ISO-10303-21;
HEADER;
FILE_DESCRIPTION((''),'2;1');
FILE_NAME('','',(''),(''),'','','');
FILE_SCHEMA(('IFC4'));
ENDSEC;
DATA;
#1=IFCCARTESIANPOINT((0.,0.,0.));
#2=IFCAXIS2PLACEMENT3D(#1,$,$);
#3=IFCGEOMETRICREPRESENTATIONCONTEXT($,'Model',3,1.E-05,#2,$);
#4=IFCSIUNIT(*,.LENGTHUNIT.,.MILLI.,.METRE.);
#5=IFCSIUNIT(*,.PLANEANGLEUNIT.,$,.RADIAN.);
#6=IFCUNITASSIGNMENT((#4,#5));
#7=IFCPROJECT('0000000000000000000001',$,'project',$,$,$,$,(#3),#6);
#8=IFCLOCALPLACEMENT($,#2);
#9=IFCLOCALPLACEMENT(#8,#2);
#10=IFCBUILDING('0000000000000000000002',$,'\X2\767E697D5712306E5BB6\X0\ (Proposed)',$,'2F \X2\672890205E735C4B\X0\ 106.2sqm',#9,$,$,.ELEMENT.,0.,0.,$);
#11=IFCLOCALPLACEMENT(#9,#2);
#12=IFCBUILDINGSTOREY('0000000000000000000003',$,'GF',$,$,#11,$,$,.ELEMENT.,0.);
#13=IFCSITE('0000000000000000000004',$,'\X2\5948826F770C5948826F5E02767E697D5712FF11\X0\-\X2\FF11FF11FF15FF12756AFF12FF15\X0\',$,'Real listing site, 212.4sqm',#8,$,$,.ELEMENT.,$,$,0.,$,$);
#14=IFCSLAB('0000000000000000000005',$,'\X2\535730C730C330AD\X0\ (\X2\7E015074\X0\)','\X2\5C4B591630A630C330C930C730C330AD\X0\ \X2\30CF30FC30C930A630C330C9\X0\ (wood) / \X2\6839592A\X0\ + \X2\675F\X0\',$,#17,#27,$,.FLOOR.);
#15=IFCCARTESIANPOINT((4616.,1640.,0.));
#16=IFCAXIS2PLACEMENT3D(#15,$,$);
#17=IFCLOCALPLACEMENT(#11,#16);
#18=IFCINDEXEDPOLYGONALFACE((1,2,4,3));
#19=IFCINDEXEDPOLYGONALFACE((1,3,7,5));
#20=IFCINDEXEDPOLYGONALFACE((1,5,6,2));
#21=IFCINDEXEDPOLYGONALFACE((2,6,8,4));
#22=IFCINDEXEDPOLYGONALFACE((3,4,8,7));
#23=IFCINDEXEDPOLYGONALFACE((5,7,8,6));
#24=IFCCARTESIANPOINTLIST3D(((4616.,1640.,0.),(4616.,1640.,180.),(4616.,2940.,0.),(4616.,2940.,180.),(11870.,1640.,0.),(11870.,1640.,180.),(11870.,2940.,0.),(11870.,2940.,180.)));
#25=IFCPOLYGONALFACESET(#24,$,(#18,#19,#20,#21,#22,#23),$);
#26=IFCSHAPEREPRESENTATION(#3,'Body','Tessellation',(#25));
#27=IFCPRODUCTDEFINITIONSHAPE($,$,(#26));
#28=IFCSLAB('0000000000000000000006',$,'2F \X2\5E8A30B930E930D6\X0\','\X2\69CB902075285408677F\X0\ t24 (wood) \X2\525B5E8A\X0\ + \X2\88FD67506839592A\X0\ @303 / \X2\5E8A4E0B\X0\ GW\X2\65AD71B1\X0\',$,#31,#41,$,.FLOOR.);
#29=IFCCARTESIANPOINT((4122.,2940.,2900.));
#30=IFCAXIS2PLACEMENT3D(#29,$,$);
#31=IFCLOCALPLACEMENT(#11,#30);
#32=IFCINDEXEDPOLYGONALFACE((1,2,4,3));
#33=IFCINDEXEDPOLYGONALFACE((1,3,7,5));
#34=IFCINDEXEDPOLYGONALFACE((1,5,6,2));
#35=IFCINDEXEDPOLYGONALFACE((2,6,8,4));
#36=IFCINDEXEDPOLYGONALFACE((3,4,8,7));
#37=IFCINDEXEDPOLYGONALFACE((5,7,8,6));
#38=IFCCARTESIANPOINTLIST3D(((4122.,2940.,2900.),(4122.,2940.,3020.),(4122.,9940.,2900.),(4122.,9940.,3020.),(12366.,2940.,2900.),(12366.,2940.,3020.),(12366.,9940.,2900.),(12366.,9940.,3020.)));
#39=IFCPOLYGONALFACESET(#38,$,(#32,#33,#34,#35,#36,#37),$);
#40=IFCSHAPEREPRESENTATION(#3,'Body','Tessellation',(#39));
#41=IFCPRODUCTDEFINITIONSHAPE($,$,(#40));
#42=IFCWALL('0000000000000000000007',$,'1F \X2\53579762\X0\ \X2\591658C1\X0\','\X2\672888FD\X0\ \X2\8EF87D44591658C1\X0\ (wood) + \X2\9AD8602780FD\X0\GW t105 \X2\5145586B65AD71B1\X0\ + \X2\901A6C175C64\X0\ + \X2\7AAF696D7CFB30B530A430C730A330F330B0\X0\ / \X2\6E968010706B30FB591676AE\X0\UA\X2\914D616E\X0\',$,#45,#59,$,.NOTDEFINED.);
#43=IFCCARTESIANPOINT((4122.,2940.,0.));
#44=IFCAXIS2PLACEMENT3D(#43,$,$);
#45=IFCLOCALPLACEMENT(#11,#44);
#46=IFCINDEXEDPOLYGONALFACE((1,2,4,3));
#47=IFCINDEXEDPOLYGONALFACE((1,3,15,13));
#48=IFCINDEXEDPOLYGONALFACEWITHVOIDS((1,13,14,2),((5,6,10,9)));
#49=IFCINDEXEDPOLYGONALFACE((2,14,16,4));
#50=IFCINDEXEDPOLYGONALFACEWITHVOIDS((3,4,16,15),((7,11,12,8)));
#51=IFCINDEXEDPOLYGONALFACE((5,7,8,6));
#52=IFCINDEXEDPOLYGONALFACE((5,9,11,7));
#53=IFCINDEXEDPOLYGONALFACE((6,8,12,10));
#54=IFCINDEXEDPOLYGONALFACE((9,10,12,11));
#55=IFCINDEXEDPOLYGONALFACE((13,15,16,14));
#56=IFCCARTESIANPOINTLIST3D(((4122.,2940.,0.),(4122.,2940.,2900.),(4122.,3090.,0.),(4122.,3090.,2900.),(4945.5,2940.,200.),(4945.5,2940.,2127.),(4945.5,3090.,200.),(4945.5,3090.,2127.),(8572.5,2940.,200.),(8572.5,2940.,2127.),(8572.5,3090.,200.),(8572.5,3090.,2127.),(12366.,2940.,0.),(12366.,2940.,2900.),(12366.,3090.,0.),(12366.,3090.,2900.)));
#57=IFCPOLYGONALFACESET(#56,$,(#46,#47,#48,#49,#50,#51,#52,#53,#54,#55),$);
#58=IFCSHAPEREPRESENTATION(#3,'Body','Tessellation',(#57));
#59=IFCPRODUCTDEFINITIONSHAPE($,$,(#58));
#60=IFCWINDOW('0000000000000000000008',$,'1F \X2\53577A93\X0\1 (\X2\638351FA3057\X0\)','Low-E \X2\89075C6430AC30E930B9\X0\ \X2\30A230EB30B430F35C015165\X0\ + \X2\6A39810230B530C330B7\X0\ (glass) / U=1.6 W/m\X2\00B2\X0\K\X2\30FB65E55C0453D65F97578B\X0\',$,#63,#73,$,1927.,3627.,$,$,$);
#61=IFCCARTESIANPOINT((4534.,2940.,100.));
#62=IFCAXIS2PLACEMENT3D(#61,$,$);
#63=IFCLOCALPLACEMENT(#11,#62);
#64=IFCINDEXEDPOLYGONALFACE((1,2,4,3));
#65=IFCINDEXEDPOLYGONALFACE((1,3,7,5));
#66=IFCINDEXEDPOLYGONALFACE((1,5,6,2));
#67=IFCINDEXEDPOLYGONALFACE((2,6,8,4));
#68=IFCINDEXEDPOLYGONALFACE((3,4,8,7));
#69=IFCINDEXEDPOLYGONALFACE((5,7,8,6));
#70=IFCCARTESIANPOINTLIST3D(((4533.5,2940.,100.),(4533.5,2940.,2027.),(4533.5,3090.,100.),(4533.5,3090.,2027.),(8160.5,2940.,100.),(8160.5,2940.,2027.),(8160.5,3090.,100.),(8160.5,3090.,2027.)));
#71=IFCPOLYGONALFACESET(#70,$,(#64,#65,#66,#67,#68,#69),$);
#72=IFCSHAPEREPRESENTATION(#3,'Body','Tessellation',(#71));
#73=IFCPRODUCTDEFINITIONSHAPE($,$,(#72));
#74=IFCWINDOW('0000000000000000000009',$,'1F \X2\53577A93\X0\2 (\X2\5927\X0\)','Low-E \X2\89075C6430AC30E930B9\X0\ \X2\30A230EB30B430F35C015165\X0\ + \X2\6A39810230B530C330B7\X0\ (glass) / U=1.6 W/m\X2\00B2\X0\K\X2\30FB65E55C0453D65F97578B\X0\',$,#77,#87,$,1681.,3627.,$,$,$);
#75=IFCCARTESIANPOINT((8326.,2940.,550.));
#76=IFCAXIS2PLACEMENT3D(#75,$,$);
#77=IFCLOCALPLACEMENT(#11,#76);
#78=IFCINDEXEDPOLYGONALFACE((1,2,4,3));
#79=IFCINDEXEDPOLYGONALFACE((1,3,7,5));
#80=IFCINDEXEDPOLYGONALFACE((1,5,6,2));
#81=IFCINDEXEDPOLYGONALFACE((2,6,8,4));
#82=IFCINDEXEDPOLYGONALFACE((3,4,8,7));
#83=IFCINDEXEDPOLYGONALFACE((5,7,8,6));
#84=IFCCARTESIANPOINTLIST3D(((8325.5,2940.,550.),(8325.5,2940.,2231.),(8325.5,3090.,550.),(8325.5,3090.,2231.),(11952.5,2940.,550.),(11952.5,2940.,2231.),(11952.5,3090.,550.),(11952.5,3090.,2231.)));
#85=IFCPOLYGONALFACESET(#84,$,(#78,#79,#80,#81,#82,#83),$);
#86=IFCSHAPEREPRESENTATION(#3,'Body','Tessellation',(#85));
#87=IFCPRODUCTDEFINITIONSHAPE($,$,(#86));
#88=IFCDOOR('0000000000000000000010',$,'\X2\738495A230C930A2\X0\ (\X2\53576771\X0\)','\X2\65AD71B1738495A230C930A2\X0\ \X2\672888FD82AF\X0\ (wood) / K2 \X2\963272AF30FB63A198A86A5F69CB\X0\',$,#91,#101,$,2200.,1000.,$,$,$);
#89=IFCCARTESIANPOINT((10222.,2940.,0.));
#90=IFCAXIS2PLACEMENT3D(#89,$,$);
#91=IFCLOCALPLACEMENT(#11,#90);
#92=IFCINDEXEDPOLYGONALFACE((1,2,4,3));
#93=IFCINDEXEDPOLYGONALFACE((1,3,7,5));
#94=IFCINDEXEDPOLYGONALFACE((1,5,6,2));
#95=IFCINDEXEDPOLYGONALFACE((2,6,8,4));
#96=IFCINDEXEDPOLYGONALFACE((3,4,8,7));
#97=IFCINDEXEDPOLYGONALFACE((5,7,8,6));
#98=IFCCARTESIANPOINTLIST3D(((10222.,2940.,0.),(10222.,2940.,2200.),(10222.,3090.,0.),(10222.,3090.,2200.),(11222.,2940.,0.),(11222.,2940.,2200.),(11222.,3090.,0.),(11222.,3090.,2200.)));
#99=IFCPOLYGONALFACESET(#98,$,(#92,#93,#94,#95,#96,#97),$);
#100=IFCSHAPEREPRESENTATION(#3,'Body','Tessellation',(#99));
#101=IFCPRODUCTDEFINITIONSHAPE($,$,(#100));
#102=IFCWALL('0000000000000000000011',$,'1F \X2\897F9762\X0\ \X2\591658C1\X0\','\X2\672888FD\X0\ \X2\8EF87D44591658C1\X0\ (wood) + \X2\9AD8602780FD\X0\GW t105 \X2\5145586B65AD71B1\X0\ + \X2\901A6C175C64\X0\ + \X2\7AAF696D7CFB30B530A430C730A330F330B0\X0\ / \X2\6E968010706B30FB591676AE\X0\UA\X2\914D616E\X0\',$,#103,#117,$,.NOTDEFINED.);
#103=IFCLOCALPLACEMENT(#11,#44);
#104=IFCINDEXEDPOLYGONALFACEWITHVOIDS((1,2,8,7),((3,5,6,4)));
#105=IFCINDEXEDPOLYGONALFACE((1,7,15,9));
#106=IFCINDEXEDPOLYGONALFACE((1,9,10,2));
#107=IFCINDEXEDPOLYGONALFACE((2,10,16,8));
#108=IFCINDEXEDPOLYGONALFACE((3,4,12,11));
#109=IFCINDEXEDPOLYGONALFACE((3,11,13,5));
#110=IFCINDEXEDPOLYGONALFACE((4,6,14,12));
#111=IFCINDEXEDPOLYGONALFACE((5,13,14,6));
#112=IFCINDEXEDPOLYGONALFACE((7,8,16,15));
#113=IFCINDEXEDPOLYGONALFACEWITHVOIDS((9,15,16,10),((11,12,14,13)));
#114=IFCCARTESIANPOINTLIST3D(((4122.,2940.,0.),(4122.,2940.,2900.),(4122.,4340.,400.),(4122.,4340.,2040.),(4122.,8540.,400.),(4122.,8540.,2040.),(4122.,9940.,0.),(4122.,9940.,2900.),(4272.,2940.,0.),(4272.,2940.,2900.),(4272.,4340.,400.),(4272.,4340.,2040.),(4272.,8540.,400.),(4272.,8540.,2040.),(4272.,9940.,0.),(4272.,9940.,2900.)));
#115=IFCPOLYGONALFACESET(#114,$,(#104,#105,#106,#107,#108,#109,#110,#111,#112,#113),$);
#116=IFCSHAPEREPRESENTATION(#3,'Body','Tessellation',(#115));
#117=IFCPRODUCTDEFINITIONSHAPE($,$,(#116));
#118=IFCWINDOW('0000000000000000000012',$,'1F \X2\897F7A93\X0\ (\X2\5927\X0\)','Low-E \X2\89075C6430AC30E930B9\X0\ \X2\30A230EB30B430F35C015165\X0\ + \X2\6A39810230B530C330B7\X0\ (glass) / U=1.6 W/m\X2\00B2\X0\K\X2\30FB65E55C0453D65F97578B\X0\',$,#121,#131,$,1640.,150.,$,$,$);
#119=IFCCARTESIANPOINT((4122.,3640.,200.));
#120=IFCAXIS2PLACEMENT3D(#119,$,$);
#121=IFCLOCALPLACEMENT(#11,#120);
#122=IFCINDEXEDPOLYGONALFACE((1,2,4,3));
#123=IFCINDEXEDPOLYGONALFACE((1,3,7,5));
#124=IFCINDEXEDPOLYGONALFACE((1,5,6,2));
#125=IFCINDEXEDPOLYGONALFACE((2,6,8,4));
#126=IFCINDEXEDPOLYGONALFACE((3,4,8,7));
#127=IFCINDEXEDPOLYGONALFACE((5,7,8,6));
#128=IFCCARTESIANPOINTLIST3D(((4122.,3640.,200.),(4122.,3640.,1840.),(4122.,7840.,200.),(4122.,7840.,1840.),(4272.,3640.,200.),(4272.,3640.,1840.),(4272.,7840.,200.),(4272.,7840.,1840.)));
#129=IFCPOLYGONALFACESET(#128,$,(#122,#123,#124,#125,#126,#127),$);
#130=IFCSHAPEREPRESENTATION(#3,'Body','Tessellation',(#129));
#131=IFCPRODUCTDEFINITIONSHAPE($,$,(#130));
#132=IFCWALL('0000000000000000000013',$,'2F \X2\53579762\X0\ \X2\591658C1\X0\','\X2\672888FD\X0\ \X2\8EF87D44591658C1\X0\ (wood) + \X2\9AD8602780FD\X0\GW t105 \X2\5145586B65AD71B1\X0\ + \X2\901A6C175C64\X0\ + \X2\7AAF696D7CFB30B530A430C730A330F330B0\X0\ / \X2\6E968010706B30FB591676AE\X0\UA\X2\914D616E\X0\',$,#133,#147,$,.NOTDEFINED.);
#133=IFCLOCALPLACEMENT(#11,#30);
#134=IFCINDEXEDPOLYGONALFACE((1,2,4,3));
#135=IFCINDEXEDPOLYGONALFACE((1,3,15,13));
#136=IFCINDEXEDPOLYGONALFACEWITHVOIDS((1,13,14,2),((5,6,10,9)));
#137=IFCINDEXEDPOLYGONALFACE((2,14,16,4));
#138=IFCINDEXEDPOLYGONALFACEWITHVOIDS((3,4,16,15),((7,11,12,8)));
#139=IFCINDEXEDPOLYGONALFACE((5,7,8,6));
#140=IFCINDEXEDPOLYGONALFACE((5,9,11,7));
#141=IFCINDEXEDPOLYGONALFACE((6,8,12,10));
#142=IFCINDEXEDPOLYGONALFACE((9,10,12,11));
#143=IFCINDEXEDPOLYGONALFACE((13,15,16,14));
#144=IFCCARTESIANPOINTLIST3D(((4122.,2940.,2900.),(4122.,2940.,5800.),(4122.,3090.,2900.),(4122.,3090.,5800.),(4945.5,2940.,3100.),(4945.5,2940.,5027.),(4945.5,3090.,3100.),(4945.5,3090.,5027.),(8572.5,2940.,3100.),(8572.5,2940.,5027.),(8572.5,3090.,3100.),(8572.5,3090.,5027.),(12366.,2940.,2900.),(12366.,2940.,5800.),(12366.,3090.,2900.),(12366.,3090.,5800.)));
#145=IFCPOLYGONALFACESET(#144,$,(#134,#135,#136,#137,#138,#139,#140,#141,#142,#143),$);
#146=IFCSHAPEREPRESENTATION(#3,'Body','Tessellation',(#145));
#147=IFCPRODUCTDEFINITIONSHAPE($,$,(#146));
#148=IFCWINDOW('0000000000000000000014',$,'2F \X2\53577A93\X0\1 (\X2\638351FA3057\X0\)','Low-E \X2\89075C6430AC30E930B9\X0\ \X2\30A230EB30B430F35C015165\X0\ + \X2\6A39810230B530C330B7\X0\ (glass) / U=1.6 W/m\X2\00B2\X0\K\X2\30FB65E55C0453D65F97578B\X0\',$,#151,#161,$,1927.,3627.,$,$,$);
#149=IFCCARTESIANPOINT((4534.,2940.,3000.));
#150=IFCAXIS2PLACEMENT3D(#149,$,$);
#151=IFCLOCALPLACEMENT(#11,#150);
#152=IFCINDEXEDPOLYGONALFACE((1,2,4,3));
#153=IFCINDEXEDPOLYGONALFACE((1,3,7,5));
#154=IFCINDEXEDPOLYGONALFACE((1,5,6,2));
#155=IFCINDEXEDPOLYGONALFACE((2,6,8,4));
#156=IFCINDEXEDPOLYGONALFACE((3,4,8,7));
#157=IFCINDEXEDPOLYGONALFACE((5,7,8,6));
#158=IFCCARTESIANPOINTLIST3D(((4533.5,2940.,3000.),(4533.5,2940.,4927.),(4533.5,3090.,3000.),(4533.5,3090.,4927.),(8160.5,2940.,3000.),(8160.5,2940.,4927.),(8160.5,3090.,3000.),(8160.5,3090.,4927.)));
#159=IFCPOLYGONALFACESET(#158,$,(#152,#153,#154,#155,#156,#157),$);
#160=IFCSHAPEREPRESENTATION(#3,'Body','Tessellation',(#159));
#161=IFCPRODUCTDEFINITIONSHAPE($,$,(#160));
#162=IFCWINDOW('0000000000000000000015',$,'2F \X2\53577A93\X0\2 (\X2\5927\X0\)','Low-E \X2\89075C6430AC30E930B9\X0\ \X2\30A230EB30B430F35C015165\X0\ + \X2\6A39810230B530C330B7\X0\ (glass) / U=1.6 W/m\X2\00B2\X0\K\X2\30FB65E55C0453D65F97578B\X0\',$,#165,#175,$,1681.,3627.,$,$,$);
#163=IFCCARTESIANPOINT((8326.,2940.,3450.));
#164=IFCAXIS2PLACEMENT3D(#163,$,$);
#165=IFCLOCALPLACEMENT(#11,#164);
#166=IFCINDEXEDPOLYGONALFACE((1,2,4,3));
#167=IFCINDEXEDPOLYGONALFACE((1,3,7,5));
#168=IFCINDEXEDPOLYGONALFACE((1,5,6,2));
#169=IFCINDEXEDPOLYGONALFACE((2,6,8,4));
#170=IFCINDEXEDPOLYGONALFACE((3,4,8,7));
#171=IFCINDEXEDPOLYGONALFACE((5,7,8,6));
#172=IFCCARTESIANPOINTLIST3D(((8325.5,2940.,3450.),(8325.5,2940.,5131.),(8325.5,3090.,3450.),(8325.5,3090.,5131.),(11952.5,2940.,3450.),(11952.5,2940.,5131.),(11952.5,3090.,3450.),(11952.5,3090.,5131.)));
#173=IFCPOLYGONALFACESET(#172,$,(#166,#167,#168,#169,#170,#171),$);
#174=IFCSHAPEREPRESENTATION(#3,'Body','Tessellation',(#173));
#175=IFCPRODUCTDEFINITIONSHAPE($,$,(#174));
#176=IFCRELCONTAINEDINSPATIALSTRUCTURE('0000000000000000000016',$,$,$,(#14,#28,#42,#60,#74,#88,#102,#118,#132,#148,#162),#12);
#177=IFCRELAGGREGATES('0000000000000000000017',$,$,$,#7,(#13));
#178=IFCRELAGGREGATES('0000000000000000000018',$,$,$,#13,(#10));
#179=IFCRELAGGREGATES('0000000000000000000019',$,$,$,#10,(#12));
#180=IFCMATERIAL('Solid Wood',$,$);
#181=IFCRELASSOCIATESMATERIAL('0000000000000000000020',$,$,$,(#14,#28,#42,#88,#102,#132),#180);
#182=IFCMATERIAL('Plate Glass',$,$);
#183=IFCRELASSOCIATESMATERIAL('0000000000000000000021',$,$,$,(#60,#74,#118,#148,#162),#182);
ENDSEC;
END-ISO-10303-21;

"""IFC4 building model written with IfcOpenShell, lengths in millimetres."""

from ifc_helpers import new_model, si_unit, frame, frame_2d, origin, place, context, project, spatial, rectangle, extrude, material, element, fill, save


model = new_model("IFC4")

# Units and contexts
model_context = context("Model", 3, precision=1e-05, world=origin())
ifc_project = project(units=[si_unit("LENGTHUNIT", "METRE", prefix="MILLI"), si_unit("PLANEANGLEUNIT", "RADIAN")], contexts=[model_context])

# Site, building, storey
site_placement = place(None, origin())
site = spatial("IfcSite", under=ifc_project, at=site_placement, Name="奈良県奈良市百楽園１-１１５２番２５", ObjectType="Real listing site, 212.4sqm", CompositionType="ELEMENT", RefElevation=0.0)
building_placement = place(site_placement, origin())
building = spatial("IfcBuilding", under=site, at=building_placement, Name="百楽園の家 (Proposed)", ObjectType="2F 木造平屋 106.2sqm", CompositionType="ELEMENT", ElevationOfRefHeight=0.0, ElevationOfTerrain=0.0)
storey_placement = place(building_placement, origin())
storey = spatial("IfcBuildingStorey", under=building, at=storey_placement, Name="GF", CompositionType="ELEMENT", Elevation=0.0)

# Slabs
ifc_material_1 = material(Name="Solid Wood")
slab_1_placement = place(storey_placement, frame((4616.0, 1640.0, 0.0)))
element("IfcSlab", 1, at=slab_1_placement, inside=storey, material=ifc_material_1, Name="南デッキ (縁側)", Description="屋外ウッドデッキ ハードウッド (wood) / 根太 + 束", PredefinedType="FLOOR", context=model_context, shape_type="SweptSolid", body=[
    extrude(rectangle(XDim=7254.0, YDim=1300.0, at=frame_2d((3627.0, 650.0))), frame((4616.0, 1640.0, 0.0)), (0.0, 0.0, 1.0), 180.0),
])
slab_2_placement = place(storey_placement, frame((4122.0, 2940.0, 2900.0)))
element("IfcSlab", 2, at=slab_2_placement, inside=storey, material=ifc_material_1, Name="2F 床スラブ", Description="構造用合板 t24 (wood) 剛床 + 製材根太 @303 / 床下 GW断熱", PredefinedType="FLOOR", context=model_context, shape_type="SweptSolid", body=[
    extrude(rectangle(XDim=8244.0, YDim=7000.0, at=frame_2d((4122.0, 3500.0))), frame((4122.0, 2940.0, 2900.0)), (0.0, 0.0, 1.0), 120.0),
])

# Wall, openings, windows, door
wall_1_placement = place(storey_placement, frame((4122.0, 2940.0, 0.0)))
wall_1 = element("IfcWall", 3, at=wall_1_placement, inside=storey, material=ifc_material_1, Name="1F 南面 外壁", Description="木製 軸組外壁 (wood) + 高性能GW t105 充填断熱 + 通気層 + 窯業系サイディング / 準耐火・外皮UA配慮", PredefinedType="NOTDEFINED", context=model_context, shape_type="SweptSolid", body=[
    extrude(rectangle(XDim=8244.0, YDim=150.0, at=frame_2d((4122.0, 75.0))), frame((4122.0, 2940.0, 0.0)), (0.0, 0.0, 1.0), 2900.0),
])
opening_1_placement = place(storey_placement, frame((4534.0, 2940.0, 100.0)))
opening_1 = element("IfcOpeningElement", 4, at=opening_1_placement, cuts=wall_1, PredefinedType="NOTDEFINED", context=model_context, shape_type="SweptSolid", body=[
    extrude(rectangle(XDim=3627.0, YDim=150.0, at=frame_2d((1813.0, 75.0))), frame((4534.0, 2940.0, 100.0)), (0.0, 0.0, 1.0), 1927.0),
])
opening_2_placement = place(storey_placement, frame((8326.0, 2940.0, 550.0)))
opening_2 = element("IfcOpeningElement", 5, at=opening_2_placement, cuts=wall_1, PredefinedType="NOTDEFINED", context=model_context, shape_type="SweptSolid", body=[
    extrude(rectangle(XDim=3627.0, YDim=150.0, at=frame_2d((1813.0, 75.0))), frame((8326.0, 2940.0, 550.0)), (0.0, 0.0, 1.0), 1681.0),
])
opening_3_placement = place(storey_placement, frame((10222.0, 2940.0, 0.0)))
opening_3 = element("IfcOpeningElement", 6, at=opening_3_placement, cuts=wall_1, PredefinedType="NOTDEFINED", context=model_context, shape_type="SweptSolid", body=[
    extrude(rectangle(XDim=1000.0, YDim=150.0, at=frame_2d((500.0, 75.0))), frame((10222.0, 2940.0, 0.0)), (0.0, 0.0, 1.0), 2200.0),
])
ifc_material_2 = material(Name="Plate Glass")
window_1_placement = place(storey_placement, frame((4534.0, 2940.0, 100.0)))
window_1 = element("IfcWindow", 7, at=window_1_placement, inside=storey, material=ifc_material_2, Name="1F 南窓1 (掃出し)", Description="Low-E 複層ガラス アルゴン封入 + 樹脂サッシ (glass) / U=1.6 W/m²K・日射取得型", OverallHeight=1927.0, OverallWidth=3627.0, context=model_context, shape_type="SweptSolid", body=[
    extrude(rectangle(XDim=3627.0, YDim=150.0, at=frame_2d((1813.0, 75.0))), frame((4534.0, 2940.0, 100.0)), (0.0, 0.0, 1.0), 1927.0),
])
fill(opening_1, window_1)
window_2_placement = place(storey_placement, frame((8326.0, 2940.0, 550.0)))
window_2 = element("IfcWindow", 8, at=window_2_placement, inside=storey, material=ifc_material_2, Name="1F 南窓2 (大)", Description="Low-E 複層ガラス アルゴン封入 + 樹脂サッシ (glass) / U=1.6 W/m²K・日射取得型", OverallHeight=1681.0, OverallWidth=3627.0, context=model_context, shape_type="SweptSolid", body=[
    extrude(rectangle(XDim=3627.0, YDim=150.0, at=frame_2d((1813.0, 75.0))), frame((8326.0, 2940.0, 550.0)), (0.0, 0.0, 1.0), 1681.0),
])
fill(opening_2, window_2)
door_placement = place(storey_placement, frame((10222.0, 2940.0, 0.0)))
door = element("IfcDoor", 9, at=door_placement, inside=storey, material=ifc_material_1, Name="玄関ドア (南東)", Description="断熱玄関ドア 木製芯 (wood) / K2 防犯・採風機構", OverallHeight=2200.0, OverallWidth=1000.0, context=model_context, shape_type="SweptSolid", body=[
    extrude(rectangle(XDim=1000.0, YDim=150.0, at=frame_2d((500.0, 75.0))), frame((10222.0, 2940.0, 0.0)), (0.0, 0.0, 1.0), 2200.0),
])
fill(opening_3, door)

# Wall, opening, window
wall_2_placement = place(storey_placement, frame((4122.0, 2940.0, 0.0)))
wall_2 = element("IfcWall", 10, at=wall_2_placement, inside=storey, material=ifc_material_1, Name="1F 西面 外壁", Description="木製 軸組外壁 (wood) + 高性能GW t105 充填断熱 + 通気層 + 窯業系サイディング / 準耐火・外皮UA配慮", PredefinedType="NOTDEFINED", context=model_context, shape_type="SweptSolid", body=[
    extrude(rectangle(XDim=150.0, YDim=7000.0, at=frame_2d((75.0, 3500.0))), frame((4122.0, 2940.0, 0.0)), (0.0, 0.0, 1.0), 2900.0),
])
opening_4_placement = place(storey_placement, frame((4122.0, 3640.0, 200.0)))
opening_4 = element("IfcOpeningElement", 11, at=opening_4_placement, cuts=wall_2, PredefinedType="NOTDEFINED", context=model_context, shape_type="SweptSolid", body=[
    extrude(rectangle(XDim=150.0, YDim=4200.0, at=frame_2d((75.0, 2100.0))), frame((4122.0, 3640.0, 200.0)), (0.0, 0.0, 1.0), 1640.0),
])
window_3_placement = place(storey_placement, frame((4122.0, 3640.0, 200.0)))
window_3 = element("IfcWindow", 12, at=window_3_placement, inside=storey, material=ifc_material_2, Name="1F 西窓 (大)", Description="Low-E 複層ガラス アルゴン封入 + 樹脂サッシ (glass) / U=1.6 W/m²K・日射取得型", OverallHeight=1640.0, OverallWidth=150.0, context=model_context, shape_type="SweptSolid", body=[
    extrude(rectangle(XDim=150.0, YDim=4200.0, at=frame_2d((75.0, 2100.0))), frame((4122.0, 3640.0, 200.0)), (0.0, 0.0, 1.0), 1640.0),
])
fill(opening_4, window_3)

# Wall, openings, windows
wall_3_placement = place(storey_placement, frame((4122.0, 2940.0, 2900.0)))
wall_3 = element("IfcWall", 13, at=wall_3_placement, inside=storey, material=ifc_material_1, Name="2F 南面 外壁", Description="木製 軸組外壁 (wood) + 高性能GW t105 充填断熱 + 通気層 + 窯業系サイディング / 準耐火・外皮UA配慮", PredefinedType="NOTDEFINED", context=model_context, shape_type="SweptSolid", body=[
    extrude(rectangle(XDim=8244.0, YDim=150.0, at=frame_2d((4122.0, 75.0))), frame((4122.0, 2940.0, 2900.0)), (0.0, 0.0, 1.0), 2900.0),
])
opening_5_placement = place(storey_placement, frame((4534.0, 2940.0, 3000.0)))
opening_5 = element("IfcOpeningElement", 14, at=opening_5_placement, cuts=wall_3, PredefinedType="NOTDEFINED", context=model_context, shape_type="SweptSolid", body=[
    extrude(rectangle(XDim=3627.0, YDim=150.0, at=frame_2d((1813.0, 75.0))), frame((4534.0, 2940.0, 3000.0)), (0.0, 0.0, 1.0), 1927.0),
])
opening_6_placement = place(storey_placement, frame((8326.0, 2940.0, 3450.0)))
opening_6 = element("IfcOpeningElement", 15, at=opening_6_placement, cuts=wall_3, PredefinedType="NOTDEFINED", context=model_context, shape_type="SweptSolid", body=[
    extrude(rectangle(XDim=3627.0, YDim=150.0, at=frame_2d((1813.0, 75.0))), frame((8326.0, 2940.0, 3450.0)), (0.0, 0.0, 1.0), 1681.0),
])
window_4_placement = place(storey_placement, frame((4534.0, 2940.0, 3000.0)))
window_4 = element("IfcWindow", 16, at=window_4_placement, inside=storey, material=ifc_material_2, Name="2F 南窓1 (掃出し)", Description="Low-E 複層ガラス アルゴン封入 + 樹脂サッシ (glass) / U=1.6 W/m²K・日射取得型", OverallHeight=1927.0, OverallWidth=3627.0, context=model_context, shape_type="SweptSolid", body=[
    extrude(rectangle(XDim=3627.0, YDim=150.0, at=frame_2d((1813.0, 75.0))), frame((4534.0, 2940.0, 3000.0)), (0.0, 0.0, 1.0), 1927.0),
])
fill(opening_5, window_4)
window_5_placement = place(storey_placement, frame((8326.0, 2940.0, 3450.0)))
window_5 = element("IfcWindow", 17, at=window_5_placement, inside=storey, material=ifc_material_2, Name="2F 南窓2 (大)", Description="Low-E 複層ガラス アルゴン封入 + 樹脂サッシ (glass) / U=1.6 W/m²K・日射取得型", OverallHeight=1681.0, OverallWidth=3627.0, context=model_context, shape_type="SweptSolid", body=[
    extrude(rectangle(XDim=3627.0, YDim=150.0, at=frame_2d((1813.0, 75.0))), frame((8326.0, 2940.0, 3450.0)), (0.0, 0.0, 1.0), 1681.0),
])
fill(opening_6, window_5)

save(model, "model.ifc")
